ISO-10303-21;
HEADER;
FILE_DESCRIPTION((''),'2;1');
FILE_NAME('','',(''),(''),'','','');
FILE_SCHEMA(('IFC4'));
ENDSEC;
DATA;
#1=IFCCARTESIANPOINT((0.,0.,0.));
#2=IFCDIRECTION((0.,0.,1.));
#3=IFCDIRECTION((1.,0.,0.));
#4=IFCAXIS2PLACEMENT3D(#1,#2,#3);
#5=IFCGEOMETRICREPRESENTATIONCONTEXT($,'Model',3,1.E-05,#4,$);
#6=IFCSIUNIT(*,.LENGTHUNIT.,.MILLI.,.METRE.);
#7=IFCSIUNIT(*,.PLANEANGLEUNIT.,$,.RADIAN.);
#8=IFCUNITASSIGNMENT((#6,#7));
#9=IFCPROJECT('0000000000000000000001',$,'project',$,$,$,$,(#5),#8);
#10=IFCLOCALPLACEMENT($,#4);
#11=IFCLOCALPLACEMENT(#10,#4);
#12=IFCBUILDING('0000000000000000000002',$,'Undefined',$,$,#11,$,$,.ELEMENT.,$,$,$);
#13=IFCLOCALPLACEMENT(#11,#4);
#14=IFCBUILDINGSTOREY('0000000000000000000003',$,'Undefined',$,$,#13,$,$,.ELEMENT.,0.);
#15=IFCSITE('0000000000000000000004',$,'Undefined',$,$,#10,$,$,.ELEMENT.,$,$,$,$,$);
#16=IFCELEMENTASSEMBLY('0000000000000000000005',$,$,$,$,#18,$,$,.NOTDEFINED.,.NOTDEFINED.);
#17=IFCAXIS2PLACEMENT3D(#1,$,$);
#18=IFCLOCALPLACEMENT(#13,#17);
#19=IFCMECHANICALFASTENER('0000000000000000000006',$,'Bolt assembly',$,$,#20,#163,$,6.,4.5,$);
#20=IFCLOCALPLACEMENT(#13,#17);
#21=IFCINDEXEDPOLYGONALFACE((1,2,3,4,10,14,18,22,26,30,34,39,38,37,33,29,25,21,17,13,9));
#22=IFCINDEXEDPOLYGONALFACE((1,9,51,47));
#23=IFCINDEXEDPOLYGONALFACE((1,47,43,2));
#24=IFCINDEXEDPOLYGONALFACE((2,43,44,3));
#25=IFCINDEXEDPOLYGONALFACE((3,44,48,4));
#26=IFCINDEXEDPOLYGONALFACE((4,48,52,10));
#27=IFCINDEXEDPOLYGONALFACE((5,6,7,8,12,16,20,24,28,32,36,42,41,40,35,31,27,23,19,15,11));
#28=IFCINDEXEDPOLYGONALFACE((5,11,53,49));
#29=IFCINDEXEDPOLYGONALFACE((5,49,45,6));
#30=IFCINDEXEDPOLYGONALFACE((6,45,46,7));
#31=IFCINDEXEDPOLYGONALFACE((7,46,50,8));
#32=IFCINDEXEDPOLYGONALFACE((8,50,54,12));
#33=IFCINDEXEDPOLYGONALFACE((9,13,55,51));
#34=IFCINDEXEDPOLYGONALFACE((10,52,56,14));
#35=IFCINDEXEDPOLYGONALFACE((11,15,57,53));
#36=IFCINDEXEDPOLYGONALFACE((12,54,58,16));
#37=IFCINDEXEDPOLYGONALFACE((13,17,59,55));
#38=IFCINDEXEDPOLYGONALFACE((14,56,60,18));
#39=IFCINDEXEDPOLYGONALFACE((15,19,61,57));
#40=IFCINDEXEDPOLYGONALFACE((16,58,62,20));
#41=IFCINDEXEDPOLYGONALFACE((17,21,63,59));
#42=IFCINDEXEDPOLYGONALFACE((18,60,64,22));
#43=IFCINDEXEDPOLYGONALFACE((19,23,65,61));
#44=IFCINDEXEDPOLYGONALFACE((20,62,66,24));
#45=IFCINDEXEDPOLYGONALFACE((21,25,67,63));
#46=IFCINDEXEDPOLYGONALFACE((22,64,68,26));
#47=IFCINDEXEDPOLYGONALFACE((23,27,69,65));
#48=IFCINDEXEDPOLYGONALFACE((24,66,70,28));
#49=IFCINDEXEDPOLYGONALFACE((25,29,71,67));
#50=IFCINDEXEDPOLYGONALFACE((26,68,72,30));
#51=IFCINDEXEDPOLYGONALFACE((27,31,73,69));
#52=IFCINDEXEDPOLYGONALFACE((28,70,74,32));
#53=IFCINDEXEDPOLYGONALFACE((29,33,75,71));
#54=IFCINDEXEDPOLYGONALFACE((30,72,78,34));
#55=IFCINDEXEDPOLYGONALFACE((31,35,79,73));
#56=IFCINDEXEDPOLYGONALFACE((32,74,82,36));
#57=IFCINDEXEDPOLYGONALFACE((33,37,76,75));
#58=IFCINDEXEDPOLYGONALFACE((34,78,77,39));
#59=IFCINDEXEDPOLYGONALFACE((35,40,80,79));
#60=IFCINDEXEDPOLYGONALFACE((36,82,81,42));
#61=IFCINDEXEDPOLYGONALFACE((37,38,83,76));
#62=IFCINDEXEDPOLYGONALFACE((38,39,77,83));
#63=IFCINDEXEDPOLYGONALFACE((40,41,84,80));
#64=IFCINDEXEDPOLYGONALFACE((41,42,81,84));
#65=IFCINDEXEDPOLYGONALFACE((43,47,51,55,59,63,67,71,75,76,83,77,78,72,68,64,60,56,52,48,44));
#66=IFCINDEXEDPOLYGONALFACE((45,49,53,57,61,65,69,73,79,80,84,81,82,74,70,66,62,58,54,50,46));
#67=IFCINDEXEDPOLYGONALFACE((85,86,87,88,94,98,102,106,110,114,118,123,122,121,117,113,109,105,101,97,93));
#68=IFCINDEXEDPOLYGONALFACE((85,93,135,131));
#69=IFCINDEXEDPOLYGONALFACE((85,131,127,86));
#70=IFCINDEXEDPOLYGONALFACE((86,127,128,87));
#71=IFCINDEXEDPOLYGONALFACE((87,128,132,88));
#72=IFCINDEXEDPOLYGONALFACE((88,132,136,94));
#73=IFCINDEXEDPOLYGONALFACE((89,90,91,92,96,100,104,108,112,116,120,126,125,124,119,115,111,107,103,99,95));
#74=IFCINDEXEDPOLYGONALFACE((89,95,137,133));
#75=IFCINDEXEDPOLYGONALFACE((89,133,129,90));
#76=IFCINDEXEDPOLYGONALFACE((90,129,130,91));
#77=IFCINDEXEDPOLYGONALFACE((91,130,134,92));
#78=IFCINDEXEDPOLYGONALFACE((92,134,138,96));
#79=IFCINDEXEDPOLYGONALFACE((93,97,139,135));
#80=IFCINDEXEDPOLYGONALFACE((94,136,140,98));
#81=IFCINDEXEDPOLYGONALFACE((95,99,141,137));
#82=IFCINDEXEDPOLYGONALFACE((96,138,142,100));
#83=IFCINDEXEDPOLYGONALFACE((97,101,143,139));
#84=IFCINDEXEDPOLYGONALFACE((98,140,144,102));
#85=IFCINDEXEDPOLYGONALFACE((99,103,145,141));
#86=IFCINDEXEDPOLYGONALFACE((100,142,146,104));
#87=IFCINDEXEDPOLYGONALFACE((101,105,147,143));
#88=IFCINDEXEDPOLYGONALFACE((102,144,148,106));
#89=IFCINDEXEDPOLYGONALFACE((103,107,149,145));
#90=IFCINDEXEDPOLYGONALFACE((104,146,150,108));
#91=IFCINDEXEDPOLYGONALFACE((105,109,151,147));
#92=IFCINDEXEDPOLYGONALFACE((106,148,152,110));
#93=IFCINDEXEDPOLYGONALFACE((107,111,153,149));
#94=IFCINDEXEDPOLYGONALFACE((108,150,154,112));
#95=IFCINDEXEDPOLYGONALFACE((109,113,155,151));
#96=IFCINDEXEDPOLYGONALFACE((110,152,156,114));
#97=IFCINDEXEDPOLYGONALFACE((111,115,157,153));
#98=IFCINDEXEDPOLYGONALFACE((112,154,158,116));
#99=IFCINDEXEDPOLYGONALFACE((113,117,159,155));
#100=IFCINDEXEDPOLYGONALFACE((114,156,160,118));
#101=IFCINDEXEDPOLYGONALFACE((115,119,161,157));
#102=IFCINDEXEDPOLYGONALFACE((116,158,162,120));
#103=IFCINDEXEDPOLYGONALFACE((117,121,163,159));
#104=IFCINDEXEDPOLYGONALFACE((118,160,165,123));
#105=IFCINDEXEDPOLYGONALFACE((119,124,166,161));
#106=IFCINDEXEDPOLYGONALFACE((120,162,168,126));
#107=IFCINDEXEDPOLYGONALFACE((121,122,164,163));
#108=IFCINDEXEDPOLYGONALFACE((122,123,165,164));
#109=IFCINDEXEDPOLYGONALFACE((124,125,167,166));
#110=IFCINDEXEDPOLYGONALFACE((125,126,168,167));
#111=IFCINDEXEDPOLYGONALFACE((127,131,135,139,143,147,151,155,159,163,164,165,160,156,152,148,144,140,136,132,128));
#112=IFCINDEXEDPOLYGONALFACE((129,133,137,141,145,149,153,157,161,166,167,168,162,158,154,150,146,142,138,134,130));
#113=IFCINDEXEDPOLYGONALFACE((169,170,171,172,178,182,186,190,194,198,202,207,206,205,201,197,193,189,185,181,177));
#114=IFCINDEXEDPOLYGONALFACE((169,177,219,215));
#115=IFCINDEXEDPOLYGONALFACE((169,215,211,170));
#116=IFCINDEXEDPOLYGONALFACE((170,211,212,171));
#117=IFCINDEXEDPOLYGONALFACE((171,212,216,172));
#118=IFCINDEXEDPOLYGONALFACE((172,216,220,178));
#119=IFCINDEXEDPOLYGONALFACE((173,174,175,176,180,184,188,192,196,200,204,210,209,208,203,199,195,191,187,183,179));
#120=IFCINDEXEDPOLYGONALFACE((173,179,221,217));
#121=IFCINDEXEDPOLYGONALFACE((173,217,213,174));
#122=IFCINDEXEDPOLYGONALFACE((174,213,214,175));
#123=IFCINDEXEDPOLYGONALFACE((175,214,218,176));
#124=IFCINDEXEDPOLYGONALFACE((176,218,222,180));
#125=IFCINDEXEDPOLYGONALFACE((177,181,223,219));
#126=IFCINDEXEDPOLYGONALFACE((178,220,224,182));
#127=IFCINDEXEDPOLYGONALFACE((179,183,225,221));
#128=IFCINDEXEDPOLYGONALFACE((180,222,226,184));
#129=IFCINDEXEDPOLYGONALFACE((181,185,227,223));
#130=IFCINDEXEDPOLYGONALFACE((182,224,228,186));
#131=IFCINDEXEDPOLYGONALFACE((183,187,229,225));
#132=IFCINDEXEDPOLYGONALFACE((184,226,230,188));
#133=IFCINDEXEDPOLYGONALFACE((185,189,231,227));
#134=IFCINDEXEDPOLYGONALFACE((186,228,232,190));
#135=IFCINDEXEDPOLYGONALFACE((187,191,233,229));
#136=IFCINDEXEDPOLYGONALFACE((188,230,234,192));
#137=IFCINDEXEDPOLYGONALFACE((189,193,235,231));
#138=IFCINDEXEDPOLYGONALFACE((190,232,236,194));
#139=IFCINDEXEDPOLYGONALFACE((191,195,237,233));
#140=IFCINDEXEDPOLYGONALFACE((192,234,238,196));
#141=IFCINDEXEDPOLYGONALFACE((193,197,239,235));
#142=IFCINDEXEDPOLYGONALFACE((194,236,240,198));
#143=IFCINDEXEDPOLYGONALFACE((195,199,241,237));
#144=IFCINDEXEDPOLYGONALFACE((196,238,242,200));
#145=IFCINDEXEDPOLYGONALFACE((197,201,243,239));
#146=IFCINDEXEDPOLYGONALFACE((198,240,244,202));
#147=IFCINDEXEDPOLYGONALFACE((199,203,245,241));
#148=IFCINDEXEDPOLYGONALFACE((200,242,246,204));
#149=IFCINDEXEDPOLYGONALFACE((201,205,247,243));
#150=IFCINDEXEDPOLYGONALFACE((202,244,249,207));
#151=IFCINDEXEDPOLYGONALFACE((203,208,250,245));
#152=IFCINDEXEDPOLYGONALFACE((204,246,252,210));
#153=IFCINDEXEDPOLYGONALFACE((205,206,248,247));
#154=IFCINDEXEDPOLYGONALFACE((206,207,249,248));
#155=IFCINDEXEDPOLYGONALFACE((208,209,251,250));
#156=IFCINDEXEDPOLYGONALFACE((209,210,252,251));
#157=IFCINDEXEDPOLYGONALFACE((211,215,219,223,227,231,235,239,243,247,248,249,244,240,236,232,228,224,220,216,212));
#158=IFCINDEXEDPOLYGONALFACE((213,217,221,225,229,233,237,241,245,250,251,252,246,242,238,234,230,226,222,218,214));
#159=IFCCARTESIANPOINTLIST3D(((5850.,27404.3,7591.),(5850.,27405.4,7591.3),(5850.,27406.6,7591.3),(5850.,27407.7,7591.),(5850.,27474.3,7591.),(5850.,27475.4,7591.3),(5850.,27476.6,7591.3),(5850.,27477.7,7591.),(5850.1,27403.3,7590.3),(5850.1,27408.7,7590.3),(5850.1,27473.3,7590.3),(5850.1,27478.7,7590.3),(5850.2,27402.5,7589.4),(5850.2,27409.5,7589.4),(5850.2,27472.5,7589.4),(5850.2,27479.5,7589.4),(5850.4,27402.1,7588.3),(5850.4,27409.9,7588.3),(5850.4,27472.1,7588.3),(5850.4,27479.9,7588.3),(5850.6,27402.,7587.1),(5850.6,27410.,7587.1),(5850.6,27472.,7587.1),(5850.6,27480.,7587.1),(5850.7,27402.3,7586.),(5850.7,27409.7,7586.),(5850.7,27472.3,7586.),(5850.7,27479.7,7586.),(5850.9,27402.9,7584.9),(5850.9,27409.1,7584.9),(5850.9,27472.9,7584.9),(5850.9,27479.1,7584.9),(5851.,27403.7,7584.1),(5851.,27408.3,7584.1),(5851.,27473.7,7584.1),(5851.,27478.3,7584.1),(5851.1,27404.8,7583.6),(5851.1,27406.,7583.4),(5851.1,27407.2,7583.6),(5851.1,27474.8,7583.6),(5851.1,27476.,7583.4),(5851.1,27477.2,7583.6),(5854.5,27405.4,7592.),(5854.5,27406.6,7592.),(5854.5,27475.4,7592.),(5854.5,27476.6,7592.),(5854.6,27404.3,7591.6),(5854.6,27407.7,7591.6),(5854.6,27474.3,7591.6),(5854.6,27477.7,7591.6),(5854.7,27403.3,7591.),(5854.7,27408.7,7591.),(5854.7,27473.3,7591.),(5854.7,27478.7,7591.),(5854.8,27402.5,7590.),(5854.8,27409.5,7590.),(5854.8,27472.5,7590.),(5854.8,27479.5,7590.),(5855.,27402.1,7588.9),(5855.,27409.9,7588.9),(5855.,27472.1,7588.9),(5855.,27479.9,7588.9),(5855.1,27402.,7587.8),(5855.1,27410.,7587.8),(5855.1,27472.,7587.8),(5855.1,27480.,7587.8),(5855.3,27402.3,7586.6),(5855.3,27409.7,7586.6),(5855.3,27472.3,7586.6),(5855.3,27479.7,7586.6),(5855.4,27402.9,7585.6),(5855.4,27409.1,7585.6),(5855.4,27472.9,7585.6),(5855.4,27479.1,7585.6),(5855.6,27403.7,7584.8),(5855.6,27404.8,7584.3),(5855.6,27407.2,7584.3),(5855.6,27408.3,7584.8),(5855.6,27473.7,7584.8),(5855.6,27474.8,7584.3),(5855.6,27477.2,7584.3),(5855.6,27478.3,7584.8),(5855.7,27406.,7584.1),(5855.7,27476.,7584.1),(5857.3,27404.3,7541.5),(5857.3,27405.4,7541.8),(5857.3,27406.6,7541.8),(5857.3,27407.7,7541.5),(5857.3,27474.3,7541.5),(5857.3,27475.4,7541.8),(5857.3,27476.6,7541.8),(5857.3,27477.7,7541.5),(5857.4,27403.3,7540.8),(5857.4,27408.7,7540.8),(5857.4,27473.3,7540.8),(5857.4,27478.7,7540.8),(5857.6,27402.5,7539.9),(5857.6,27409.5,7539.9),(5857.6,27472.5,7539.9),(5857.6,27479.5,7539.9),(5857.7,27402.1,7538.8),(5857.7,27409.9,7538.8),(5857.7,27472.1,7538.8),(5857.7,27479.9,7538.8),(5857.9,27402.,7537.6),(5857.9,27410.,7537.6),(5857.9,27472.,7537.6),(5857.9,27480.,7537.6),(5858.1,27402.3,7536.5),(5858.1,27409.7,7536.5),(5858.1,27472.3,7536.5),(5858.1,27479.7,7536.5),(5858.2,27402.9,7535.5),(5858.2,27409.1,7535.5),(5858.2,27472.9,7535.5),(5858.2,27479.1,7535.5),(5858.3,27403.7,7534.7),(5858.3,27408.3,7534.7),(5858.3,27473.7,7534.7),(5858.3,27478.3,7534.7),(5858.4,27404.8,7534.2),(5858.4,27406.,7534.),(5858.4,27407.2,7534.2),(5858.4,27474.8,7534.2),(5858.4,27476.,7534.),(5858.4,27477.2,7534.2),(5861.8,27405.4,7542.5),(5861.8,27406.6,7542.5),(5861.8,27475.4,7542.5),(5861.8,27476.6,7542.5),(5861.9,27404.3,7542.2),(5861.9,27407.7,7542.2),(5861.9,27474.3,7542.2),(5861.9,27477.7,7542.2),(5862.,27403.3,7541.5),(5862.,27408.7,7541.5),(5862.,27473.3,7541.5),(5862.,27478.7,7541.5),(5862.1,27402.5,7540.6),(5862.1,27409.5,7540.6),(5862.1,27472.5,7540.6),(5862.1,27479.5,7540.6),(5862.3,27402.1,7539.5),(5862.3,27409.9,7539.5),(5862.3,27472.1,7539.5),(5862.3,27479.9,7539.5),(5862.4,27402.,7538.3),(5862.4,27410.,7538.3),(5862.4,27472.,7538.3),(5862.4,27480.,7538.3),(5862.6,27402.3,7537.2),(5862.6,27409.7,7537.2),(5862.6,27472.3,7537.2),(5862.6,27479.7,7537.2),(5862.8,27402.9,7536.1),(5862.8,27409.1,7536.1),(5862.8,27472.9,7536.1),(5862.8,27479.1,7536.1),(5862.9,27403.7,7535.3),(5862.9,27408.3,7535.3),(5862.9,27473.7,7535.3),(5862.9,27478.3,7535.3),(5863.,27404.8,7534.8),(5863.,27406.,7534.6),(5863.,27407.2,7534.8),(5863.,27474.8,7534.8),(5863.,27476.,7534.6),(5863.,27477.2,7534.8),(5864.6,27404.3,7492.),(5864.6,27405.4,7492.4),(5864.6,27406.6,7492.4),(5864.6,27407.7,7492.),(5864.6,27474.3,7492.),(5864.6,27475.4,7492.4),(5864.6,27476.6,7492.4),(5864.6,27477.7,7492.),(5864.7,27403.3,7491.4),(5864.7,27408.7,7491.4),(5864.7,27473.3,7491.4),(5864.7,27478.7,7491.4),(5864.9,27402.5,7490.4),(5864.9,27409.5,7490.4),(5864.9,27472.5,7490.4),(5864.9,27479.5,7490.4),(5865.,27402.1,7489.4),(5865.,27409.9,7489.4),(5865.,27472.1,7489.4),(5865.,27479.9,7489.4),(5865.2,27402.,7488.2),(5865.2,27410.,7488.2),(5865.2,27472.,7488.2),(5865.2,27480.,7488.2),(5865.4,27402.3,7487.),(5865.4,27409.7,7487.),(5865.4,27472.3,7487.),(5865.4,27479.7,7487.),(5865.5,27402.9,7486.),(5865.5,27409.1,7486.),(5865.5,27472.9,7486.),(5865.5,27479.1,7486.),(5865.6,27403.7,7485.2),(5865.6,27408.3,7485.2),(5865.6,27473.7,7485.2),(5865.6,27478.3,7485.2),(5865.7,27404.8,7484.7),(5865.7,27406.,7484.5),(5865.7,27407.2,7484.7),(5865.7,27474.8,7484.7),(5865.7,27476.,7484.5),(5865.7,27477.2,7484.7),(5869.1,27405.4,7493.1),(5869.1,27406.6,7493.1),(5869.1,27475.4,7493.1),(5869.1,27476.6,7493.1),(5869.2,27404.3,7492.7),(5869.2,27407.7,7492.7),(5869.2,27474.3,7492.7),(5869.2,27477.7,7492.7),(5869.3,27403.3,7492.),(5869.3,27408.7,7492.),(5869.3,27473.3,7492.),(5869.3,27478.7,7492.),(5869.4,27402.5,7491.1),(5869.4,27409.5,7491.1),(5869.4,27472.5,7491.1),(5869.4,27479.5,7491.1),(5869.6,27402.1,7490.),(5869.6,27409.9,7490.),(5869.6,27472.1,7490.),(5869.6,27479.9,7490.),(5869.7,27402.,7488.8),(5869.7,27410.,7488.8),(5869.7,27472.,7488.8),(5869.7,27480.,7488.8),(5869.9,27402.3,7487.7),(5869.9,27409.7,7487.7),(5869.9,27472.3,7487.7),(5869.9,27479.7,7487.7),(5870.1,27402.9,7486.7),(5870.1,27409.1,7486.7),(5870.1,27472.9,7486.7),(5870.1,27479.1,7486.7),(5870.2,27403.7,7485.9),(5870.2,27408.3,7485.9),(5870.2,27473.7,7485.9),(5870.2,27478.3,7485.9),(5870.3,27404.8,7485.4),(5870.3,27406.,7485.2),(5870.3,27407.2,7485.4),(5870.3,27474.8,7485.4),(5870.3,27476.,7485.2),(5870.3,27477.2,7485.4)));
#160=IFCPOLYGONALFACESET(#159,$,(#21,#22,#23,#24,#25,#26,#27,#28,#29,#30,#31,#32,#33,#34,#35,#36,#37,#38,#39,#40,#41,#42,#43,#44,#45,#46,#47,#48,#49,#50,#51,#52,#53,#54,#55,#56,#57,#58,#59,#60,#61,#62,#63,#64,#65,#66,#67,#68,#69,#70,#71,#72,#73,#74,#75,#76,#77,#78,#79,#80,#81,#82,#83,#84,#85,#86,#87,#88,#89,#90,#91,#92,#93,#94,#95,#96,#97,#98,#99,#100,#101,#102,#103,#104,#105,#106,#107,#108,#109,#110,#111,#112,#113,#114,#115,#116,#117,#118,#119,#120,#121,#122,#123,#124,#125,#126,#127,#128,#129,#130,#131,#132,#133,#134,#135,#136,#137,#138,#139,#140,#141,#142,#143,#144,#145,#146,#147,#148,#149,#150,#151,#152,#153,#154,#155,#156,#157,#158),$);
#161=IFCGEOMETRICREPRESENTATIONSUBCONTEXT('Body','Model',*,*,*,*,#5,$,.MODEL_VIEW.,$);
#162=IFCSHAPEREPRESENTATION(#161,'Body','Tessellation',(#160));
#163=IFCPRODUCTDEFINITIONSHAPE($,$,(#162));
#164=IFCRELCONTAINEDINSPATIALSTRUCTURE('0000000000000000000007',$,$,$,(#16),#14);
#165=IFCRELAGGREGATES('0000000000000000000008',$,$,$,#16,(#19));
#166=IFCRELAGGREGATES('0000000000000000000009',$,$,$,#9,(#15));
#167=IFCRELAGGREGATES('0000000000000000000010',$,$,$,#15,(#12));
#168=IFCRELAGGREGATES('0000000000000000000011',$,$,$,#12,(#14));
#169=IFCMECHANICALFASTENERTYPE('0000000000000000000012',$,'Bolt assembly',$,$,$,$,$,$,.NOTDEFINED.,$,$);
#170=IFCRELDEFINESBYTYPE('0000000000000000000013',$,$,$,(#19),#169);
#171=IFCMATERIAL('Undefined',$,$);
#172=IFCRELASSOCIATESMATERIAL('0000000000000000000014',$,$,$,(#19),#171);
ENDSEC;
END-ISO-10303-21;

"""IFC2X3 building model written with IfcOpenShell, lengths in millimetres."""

from ifc_helpers import new_model, si_unit, frame, origin_with_axes, origin_2d_with_axis, place, context, subcontext, project, spatial, circle, extrude, source, transform, mapped, material, type_object, element, aggregate, save


model = new_model("IFC2X3")

# Units and contexts
model_context = context("Model", 3, precision=1e-05, world=origin_with_axes())
body_context = subcontext(model_context, "Body", "Model", "MODEL_VIEW")
ifc_project = project(units=[si_unit("LENGTHUNIT", "METRE", prefix="MILLI"), si_unit("PLANEANGLEUNIT", "RADIAN")], contexts=[model_context])

# Site, building, storey
site_placement = place(None, origin_with_axes())
site = spatial("IfcSite", under=ifc_project, at=site_placement, Name="Undefined", CompositionType="ELEMENT")
building_placement = place(site_placement, origin_with_axes())
building = spatial("IfcBuilding", under=site, at=building_placement, Name="Undefined", CompositionType="ELEMENT")
storey_placement = place(building_placement, origin_with_axes())
storey = spatial("IfcBuildingStorey", under=building, at=storey_placement, Name="Undefined", CompositionType="ELEMENT", Elevation=0.0)

# Element assembly
assembly_1_placement = place(storey_placement, origin_with_axes())
assembly_1 = element("IfcElementAssembly", 1, at=assembly_1_placement, inside=storey, AssemblyPlace="NOTDEFINED", PredefinedType="NOTDEFINED")

# Mechanical fastener
ifc_material_1 = material(Name="Undefined")
mechanical_fastener_type = type_object("IfcMechanicalFastenerType", Name="Bolt assembly")
shared_shape_1 = source(origin_with_axes(), body_context, "Body", "SweptSolid", [
    extrude(circle(Radius=4.0, at=origin_2d_with_axis()), frame((0.0, 0.0, 0.0), z_axis=(0.0, 1.0, 0.0), x_axis=(1.0, 0.0, 0.0)), (0.0, 0.0, 1.0), 4.6),
])
mechanical_fastener_1_placement = place(assembly_1_placement, frame((5850.5, 27441.0, 7587.4), z_axis=(0.0, -1.0, 0.0), x_axis=(0.146203, 0.0, -0.989255)))
mechanical_fastener_1 = element("IfcMechanicalFastener", 2, at=mechanical_fastener_1_placement, type_object=mechanical_fastener_type, material=ifc_material_1, Name="Bolt assembly", NominalDiameter=6.0, NominalLength=4.5, context=body_context, shape_type="MappedRepresentation", body=[
    mapped(shared_shape_1, transform((0.0, 0.0, -35.0))),
    mapped(shared_shape_1, transform((50.0, 0.0, -35.0))),
    mapped(shared_shape_1, transform((100.0, 0.0, -35.0))),
    mapped(shared_shape_1, transform((0.0, 0.0, 35.0))),
    mapped(shared_shape_1, transform((50.0, 0.0, 35.0))),
    mapped(shared_shape_1, transform((100.0, 0.0, 35.0))),
])

aggregate(assembly_1, [mechanical_fastener_1])

save(model, "model.ifc")
